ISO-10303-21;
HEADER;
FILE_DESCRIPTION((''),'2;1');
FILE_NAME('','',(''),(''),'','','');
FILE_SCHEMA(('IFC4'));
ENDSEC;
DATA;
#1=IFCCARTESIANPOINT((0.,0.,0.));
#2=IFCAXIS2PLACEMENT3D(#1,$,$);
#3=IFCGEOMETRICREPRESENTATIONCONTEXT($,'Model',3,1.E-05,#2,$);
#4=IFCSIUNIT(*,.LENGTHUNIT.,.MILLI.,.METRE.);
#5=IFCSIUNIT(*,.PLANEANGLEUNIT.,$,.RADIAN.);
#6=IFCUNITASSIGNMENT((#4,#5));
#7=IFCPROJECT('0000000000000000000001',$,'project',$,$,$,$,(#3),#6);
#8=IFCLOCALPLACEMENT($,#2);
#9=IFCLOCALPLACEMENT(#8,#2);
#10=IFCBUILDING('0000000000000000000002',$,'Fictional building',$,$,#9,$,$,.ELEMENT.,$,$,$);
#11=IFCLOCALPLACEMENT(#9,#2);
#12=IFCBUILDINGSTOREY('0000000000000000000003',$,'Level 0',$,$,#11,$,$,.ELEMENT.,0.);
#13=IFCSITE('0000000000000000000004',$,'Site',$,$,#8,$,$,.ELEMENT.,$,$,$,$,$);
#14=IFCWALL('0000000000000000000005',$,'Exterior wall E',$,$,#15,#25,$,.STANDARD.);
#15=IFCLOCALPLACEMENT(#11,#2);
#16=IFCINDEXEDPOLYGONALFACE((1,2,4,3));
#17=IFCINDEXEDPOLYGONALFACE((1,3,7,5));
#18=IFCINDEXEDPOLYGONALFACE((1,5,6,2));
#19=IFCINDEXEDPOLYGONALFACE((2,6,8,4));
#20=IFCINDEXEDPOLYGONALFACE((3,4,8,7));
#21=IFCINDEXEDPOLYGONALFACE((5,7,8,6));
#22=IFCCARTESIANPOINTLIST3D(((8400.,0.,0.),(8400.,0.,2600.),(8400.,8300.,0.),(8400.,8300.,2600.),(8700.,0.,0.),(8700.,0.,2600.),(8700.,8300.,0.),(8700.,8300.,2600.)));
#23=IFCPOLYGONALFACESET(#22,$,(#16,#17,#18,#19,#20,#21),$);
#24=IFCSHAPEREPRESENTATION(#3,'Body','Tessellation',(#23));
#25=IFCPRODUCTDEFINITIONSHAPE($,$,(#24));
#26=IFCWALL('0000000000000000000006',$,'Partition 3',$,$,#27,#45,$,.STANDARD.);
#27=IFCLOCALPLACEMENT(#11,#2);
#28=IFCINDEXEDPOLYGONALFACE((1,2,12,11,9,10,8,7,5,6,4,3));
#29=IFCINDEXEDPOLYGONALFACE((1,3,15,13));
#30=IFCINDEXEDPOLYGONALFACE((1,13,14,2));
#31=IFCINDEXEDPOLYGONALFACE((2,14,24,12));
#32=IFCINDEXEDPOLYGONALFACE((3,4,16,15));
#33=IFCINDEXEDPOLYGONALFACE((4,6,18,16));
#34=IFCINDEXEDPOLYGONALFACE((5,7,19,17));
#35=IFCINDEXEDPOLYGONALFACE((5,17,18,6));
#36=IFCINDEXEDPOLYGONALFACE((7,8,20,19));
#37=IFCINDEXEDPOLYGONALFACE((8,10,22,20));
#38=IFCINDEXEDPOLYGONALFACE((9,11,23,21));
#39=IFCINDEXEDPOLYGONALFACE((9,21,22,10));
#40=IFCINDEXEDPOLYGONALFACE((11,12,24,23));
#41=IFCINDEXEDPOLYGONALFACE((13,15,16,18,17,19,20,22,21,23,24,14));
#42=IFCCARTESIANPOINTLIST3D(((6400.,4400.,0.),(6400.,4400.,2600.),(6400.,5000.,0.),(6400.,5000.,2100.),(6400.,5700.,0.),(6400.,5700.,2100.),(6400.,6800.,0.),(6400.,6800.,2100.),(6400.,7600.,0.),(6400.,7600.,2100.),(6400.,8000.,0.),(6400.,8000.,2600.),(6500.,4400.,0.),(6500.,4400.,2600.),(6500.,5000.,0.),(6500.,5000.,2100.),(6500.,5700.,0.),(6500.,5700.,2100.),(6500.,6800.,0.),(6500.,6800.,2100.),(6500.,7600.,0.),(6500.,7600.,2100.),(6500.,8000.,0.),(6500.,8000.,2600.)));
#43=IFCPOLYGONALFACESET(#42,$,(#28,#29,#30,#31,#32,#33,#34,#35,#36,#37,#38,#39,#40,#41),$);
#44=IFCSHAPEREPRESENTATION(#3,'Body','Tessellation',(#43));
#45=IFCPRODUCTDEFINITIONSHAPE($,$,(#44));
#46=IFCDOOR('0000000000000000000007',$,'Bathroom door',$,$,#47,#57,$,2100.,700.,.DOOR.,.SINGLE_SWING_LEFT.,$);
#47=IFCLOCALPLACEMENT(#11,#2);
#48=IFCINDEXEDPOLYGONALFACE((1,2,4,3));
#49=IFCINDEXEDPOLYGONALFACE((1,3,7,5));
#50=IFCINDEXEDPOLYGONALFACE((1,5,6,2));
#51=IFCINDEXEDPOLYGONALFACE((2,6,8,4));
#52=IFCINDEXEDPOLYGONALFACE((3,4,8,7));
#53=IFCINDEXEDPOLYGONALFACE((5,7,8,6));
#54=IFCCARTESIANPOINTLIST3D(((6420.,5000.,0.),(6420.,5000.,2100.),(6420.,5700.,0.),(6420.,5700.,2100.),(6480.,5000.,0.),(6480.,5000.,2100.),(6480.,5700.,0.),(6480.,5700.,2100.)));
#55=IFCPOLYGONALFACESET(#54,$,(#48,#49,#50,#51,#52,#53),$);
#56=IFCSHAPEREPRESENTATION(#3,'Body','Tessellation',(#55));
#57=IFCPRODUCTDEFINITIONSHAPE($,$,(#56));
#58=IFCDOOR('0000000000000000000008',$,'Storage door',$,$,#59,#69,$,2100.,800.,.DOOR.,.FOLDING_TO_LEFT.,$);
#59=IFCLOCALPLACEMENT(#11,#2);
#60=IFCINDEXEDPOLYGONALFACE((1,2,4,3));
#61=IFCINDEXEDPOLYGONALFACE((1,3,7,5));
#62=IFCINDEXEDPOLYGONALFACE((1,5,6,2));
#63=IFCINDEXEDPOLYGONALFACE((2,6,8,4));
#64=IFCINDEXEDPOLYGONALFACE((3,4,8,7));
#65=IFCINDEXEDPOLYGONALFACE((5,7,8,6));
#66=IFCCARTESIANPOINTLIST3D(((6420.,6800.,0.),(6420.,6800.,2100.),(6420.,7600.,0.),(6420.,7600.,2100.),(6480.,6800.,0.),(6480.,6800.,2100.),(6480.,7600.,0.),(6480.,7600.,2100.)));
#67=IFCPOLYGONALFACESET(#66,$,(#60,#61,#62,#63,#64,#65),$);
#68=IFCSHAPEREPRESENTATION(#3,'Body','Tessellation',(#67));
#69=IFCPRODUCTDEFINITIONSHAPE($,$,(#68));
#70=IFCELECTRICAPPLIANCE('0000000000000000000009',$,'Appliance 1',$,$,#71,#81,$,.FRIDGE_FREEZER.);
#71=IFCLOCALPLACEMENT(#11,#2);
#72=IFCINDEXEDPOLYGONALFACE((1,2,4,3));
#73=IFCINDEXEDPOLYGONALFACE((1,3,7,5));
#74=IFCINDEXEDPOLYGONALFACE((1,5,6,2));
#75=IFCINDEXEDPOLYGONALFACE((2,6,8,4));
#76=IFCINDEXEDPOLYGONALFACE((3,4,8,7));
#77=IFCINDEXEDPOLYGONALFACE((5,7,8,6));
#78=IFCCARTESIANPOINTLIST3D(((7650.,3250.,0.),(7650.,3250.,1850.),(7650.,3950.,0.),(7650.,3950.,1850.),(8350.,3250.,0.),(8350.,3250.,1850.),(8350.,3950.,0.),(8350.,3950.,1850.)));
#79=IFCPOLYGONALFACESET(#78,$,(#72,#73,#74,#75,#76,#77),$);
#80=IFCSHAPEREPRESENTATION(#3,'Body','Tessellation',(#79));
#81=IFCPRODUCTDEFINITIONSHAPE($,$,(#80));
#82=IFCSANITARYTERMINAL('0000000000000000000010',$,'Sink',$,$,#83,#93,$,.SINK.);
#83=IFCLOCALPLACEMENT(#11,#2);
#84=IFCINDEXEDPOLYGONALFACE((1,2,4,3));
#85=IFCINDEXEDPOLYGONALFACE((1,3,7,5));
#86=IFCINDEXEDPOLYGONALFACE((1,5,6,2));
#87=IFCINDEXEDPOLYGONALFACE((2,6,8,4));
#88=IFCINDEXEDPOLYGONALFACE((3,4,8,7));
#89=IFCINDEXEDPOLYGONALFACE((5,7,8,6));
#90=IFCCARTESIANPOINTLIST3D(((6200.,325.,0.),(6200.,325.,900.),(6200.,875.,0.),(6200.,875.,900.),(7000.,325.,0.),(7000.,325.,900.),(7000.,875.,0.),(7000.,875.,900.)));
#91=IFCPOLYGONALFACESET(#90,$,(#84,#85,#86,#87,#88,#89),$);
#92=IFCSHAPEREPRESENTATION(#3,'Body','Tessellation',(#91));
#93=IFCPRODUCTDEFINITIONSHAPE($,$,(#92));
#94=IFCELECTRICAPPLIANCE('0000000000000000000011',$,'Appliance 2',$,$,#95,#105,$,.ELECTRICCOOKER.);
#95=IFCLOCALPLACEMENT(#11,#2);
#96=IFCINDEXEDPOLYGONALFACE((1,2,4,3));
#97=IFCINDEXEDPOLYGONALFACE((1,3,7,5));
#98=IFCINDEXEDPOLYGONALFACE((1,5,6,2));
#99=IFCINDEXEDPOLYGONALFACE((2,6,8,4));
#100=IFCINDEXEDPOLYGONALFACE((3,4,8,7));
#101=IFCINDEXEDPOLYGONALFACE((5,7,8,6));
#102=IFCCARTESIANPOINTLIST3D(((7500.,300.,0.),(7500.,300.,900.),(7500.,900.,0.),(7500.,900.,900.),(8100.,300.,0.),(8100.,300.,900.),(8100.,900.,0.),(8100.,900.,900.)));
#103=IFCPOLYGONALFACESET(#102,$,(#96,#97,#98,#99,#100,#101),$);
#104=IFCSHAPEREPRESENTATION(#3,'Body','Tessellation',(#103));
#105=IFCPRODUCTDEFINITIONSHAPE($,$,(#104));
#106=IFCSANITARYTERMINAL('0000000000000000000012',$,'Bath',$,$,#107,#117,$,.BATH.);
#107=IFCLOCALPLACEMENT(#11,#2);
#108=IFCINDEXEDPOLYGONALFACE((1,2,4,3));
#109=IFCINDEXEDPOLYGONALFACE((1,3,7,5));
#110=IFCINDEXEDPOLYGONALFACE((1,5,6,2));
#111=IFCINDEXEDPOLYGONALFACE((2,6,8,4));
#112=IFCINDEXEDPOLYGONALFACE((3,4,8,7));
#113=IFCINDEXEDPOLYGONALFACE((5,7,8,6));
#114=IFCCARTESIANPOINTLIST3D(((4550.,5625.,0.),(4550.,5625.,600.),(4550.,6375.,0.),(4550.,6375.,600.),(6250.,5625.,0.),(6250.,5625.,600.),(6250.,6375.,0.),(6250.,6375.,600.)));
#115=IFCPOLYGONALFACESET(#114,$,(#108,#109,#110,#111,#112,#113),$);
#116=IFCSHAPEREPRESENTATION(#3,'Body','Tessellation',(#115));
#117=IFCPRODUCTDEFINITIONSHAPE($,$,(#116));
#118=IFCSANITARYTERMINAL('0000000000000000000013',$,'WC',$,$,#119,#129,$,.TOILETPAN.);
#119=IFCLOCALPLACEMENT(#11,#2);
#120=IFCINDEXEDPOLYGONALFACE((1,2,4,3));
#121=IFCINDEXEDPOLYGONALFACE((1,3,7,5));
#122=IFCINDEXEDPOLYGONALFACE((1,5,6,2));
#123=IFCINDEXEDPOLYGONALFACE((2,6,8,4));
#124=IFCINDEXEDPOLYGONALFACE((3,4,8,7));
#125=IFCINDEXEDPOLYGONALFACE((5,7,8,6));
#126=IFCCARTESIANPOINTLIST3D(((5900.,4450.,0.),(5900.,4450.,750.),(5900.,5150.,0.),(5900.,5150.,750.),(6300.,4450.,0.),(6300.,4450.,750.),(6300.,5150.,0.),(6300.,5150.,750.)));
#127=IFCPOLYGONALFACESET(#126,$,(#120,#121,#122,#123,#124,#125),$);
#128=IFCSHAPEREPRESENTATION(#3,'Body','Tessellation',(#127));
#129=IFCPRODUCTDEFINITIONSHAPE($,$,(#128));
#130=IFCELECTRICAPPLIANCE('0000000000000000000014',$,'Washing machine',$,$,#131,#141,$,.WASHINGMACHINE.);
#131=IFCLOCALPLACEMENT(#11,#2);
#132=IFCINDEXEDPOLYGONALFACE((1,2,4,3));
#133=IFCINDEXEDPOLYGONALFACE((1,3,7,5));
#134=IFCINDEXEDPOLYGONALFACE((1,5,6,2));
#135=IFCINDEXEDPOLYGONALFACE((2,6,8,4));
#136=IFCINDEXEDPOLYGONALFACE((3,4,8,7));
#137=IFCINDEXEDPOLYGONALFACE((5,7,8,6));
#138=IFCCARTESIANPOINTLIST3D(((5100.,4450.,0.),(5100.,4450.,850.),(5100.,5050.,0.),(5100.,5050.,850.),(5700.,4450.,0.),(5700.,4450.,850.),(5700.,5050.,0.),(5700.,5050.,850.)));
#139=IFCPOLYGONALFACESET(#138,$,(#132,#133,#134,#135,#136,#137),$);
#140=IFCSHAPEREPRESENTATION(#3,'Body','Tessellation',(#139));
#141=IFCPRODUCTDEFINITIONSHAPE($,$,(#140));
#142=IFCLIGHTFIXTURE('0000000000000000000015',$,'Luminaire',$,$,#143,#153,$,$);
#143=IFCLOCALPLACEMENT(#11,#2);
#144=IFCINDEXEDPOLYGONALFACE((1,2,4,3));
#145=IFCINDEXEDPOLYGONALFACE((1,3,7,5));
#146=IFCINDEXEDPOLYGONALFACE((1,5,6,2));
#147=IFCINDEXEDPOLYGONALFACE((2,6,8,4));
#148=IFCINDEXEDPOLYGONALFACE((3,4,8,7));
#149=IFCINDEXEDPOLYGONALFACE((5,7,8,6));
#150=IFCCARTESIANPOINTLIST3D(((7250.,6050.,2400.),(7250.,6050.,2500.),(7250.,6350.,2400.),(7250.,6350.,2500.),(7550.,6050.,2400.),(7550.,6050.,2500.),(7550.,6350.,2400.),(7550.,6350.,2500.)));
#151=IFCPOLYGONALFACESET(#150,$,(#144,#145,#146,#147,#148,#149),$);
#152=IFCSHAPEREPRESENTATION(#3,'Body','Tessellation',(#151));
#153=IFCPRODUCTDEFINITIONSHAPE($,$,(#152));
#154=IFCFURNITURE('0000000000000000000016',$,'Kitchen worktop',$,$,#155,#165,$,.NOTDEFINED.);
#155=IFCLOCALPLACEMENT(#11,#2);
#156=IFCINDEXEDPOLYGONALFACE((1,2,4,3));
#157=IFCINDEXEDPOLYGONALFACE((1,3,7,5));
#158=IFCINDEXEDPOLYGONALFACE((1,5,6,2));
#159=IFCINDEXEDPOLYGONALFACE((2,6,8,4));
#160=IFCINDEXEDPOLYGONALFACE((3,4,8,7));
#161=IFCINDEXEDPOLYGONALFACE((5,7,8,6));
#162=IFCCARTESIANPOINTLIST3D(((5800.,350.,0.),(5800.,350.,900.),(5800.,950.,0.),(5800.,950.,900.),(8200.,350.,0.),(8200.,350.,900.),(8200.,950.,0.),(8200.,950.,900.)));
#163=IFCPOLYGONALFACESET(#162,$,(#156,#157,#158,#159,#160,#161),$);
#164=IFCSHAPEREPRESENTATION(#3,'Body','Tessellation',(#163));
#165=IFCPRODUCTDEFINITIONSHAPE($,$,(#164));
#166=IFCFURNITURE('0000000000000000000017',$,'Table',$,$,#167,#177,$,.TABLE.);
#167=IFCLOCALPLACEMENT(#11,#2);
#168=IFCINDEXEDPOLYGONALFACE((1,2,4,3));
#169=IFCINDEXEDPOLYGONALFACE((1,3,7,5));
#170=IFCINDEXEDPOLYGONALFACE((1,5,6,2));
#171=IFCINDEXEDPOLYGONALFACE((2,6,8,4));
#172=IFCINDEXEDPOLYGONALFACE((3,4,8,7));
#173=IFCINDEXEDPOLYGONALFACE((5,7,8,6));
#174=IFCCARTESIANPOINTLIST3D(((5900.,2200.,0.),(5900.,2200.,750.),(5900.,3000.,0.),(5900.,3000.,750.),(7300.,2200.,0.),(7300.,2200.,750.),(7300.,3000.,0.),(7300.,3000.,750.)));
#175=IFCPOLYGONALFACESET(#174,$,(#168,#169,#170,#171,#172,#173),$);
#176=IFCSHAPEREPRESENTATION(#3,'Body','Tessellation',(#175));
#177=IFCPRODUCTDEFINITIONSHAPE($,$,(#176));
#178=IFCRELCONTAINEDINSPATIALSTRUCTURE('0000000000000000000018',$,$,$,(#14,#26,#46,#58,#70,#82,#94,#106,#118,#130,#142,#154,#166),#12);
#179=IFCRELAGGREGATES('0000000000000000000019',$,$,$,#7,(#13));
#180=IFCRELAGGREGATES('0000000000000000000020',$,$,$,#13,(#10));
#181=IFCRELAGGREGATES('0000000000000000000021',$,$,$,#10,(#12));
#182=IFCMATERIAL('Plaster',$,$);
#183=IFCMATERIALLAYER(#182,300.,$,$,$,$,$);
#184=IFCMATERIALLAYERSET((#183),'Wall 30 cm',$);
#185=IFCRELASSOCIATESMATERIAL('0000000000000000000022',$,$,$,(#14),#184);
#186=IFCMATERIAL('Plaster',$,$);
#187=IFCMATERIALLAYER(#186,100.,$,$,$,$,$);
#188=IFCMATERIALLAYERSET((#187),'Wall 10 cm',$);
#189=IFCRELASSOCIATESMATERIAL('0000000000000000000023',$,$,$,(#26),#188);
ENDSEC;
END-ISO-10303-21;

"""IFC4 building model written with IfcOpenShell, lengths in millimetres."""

from ifc_helpers import new_model, si_unit, frame, frame_2d, origin, origin_2d, place, context, project, spatial, rectangle, extrude, source, transform, mapped, material, layer, layer_set, layer_usage, element, fill, save


model = new_model("IFC4")

# Units and contexts
model_context = context("Model", 3, precision=1e-05, world=origin())
ifc_project = project(units=[si_unit("LENGTHUNIT", "METRE", prefix="MILLI"), si_unit("PLANEANGLEUNIT", "RADIAN")], contexts=[model_context])

# Site, building, storey
site_placement = place(None, origin())
site = spatial("IfcSite", under=ifc_project, at=site_placement, Name="Site", CompositionType="ELEMENT")
building_placement = place(site_placement, origin())
building = spatial("IfcBuilding", under=site, at=building_placement, Name="Fictional building", CompositionType="ELEMENT")
storey_placement = place(building_placement, origin())
storey = spatial("IfcBuildingStorey", under=building, at=storey_placement, Name="Level 0", CompositionType="ELEMENT", Elevation=0.0)

# Wall
ifc_material_1 = material(Name="Plaster")
ifc_layer_1 = layer(ifc_material_1, 300.0)
ifc_layer_set_1 = layer_set([ifc_layer_1], Name="Wall 30 cm")
ifc_layer_usage_1 = layer_usage(ifc_layer_set_1, "AXIS2", "POSITIVE", -150.0)
wall_1_placement = place(storey_placement, frame((8550.0, 0.0, 0.0), z_axis=(0.0, 0.0, 1.0), x_axis=(0.0, 1.0, 0.0)))
element("IfcWall", 1, at=wall_1_placement, inside=storey, material=ifc_layer_usage_1, Name="Exterior wall E", PredefinedType="STANDARD", context=model_context, shape_type="SweptSolid", body=[
    extrude(rectangle(XDim=8300.0, YDim=300.0, at=frame_2d((4150.0, 0.0))), origin(), (0.0, 0.0, 1.0), 2600.0),
])

# Wall, openings, doors
ifc_material_2 = material(Name="Plaster")
ifc_layer_2 = layer(ifc_material_2, 100.0)
ifc_layer_set_2 = layer_set([ifc_layer_2], Name="Wall 10 cm")
ifc_layer_usage_2 = layer_usage(ifc_layer_set_2, "AXIS2", "POSITIVE", -50.0)
wall_2_placement = place(storey_placement, frame((6450.0, 4400.0, 0.0), z_axis=(0.0, 0.0, 1.0), x_axis=(0.0, 1.0, 0.0)))
wall_2 = element("IfcWall", 2, at=wall_2_placement, inside=storey, material=ifc_layer_usage_2, Name="Partition 3", PredefinedType="STANDARD", context=model_context, shape_type="SweptSolid", body=[
    extrude(rectangle(XDim=3600.0, YDim=100.0, at=frame_2d((1800.0, 0.0))), origin(), (0.0, 0.0, 1.0), 2600.0),
])
opening_1_placement = place(storey_placement, frame((6450.0, 5000.0, 0.0), z_axis=(0.0, 0.0, 1.0), x_axis=(0.0, 1.0, 0.0)))
opening_1 = element("IfcOpeningElement", 3, at=opening_1_placement, cuts=wall_2, PredefinedType="OPENING", context=model_context, shape_type="SweptSolid", body=[
    extrude(rectangle(XDim=700.0, YDim=200.0, at=frame_2d((350.0, 0.0))), origin(), (0.0, 0.0, 1.0), 2100.0),
])
opening_2_placement = place(storey_placement, frame((6450.0, 6800.0, 0.0), z_axis=(0.0, 0.0, 1.0), x_axis=(0.0, 1.0, 0.0)))
opening_2 = element("IfcOpeningElement", 4, at=opening_2_placement, cuts=wall_2, PredefinedType="OPENING", context=model_context, shape_type="SweptSolid", body=[
    extrude(rectangle(XDim=800.0, YDim=200.0, at=frame_2d((400.0, 0.0))), origin(), (0.0, 0.0, 1.0), 2100.0),
])
door_1_placement = place(opening_1_placement, origin())
door_1 = element("IfcDoor", 5, at=door_1_placement, inside=storey, Name="Bathroom door", OperationType="SINGLE_SWING_LEFT", OverallHeight=2100.0, OverallWidth=700.0, PredefinedType="DOOR", context=model_context, shape_type="SweptSolid", body=[
    extrude(rectangle(XDim=700.0, YDim=60.0, at=frame_2d((350.0, 0.0))), origin(), (0.0, 0.0, 1.0), 2100.0),
])
fill(opening_1, door_1)
door_2_placement = place(opening_2_placement, origin())
door_2 = element("IfcDoor", 6, at=door_2_placement, inside=storey, Name="Storage door", OperationType="FOLDING_TO_LEFT", OverallHeight=2100.0, OverallWidth=800.0, PredefinedType="DOOR", context=model_context, shape_type="SweptSolid", body=[
    extrude(rectangle(XDim=800.0, YDim=60.0, at=frame_2d((400.0, 0.0))), origin(), (0.0, 0.0, 1.0), 2100.0),
])
fill(opening_2, door_2)

# Electric appliance
shared_shape_1 = source(origin(), model_context, "Body", "SweptSolid", [
    extrude(rectangle(XDim=700.0, YDim=700.0, at=origin_2d()), origin(), (0.0, 0.0, 1.0), 1850.0),
])
electric_appliance_1_placement = place(storey_placement, frame((8000.0, 3600.0, 0.0), z_axis=(0.0, 0.0, 1.0), x_axis=(0.0, -1.0, 0.0)))
element("IfcElectricAppliance", 7, at=electric_appliance_1_placement, inside=storey, Name="Appliance 1", PredefinedType="FRIDGE_FREEZER", context=model_context, shape_type="MappedRepresentation", body=[
    mapped(shared_shape_1, transform((0.0, 0.0, 0.0), scale=1.0)),
])

# Sanitary terminal
shared_shape_2 = source(origin(), model_context, "Body", "SweptSolid", [
    extrude(rectangle(XDim=800.0, YDim=550.0, at=origin_2d()), origin(), (0.0, 0.0, 1.0), 900.0),
])
sanitary_terminal_1_placement = place(storey_placement, frame((6600.0, 600.0, 0.0)))
element("IfcSanitaryTerminal", 8, at=sanitary_terminal_1_placement, inside=storey, Name="Sink", PredefinedType="SINK", context=model_context, shape_type="MappedRepresentation", body=[
    mapped(shared_shape_2, transform((0.0, 0.0, 0.0), scale=1.0)),
])

# Electric appliance
shared_shape_3 = source(origin(), model_context, "Body", "SweptSolid", [
    extrude(rectangle(XDim=600.0, YDim=600.0, at=origin_2d()), origin(), (0.0, 0.0, 1.0), 900.0),
])
electric_appliance_2_placement = place(storey_placement, frame((7800.0, 600.0, 0.0)))
element("IfcElectricAppliance", 9, at=electric_appliance_2_placement, inside=storey, Name="Appliance 2", PredefinedType="ELECTRICCOOKER", context=model_context, shape_type="MappedRepresentation", body=[
    mapped(shared_shape_3, transform((0.0, 0.0, 0.0), scale=1.0)),
])

# Sanitary terminals
shared_shape_4 = source(origin(), model_context, "Body", "SweptSolid", [
    extrude(rectangle(XDim=1700.0, YDim=750.0, at=origin_2d()), origin(), (0.0, 0.0, 1.0), 600.0),
])
sanitary_terminal_2_placement = place(storey_placement, frame((5400.0, 6000.0, 0.0)))
element("IfcSanitaryTerminal", 10, at=sanitary_terminal_2_placement, inside=storey, Name="Bath", PredefinedType="BATH", context=model_context, shape_type="MappedRepresentation", body=[
    mapped(shared_shape_4, transform((0.0, 0.0, 0.0), scale=1.0)),
])
shared_shape_5 = source(origin(), model_context, "Body", "SweptSolid", [
    extrude(rectangle(XDim=400.0, YDim=700.0, at=origin_2d()), origin(), (0.0, 0.0, 1.0), 750.0),
])
sanitary_terminal_3_placement = place(storey_placement, frame((6100.0, 4800.0, 0.0)))
element("IfcSanitaryTerminal", 11, at=sanitary_terminal_3_placement, inside=storey, Name="WC", PredefinedType="TOILETPAN", context=model_context, shape_type="MappedRepresentation", body=[
    mapped(shared_shape_5, transform((0.0, 0.0, 0.0), scale=1.0)),
])

# Electric appliance
shared_shape_6 = source(origin(), model_context, "Body", "SweptSolid", [
    extrude(rectangle(XDim=600.0, YDim=600.0, at=origin_2d()), origin(), (0.0, 0.0, 1.0), 850.0),
])
electric_appliance_3_placement = place(storey_placement, frame((5400.0, 4750.0, 0.0)))
element("IfcElectricAppliance", 12, at=electric_appliance_3_placement, inside=storey, Name="Washing machine", PredefinedType="WASHINGMACHINE", context=model_context, shape_type="MappedRepresentation", body=[
    mapped(shared_shape_6, transform((0.0, 0.0, 0.0), scale=1.0)),
])

# Light fixture
shared_shape_7 = source(origin(), model_context, "Body", "SweptSolid", [
    extrude(rectangle(XDim=300.0, YDim=300.0, at=origin_2d()), origin(), (0.0, 0.0, 1.0), 100.0),
])
light_fixture_placement = place(storey_placement, frame((7400.0, 6200.0, 2400.0)))
element("IfcLightFixture", 13, at=light_fixture_placement, inside=storey, Name="Luminaire", context=model_context, shape_type="MappedRepresentation", body=[
    mapped(shared_shape_7, transform((0.0, 0.0, 0.0), scale=1.0)),
])

# Furniture
shared_shape_8 = source(origin(), model_context, "Body", "SweptSolid", [
    extrude(rectangle(XDim=2400.0, YDim=600.0, at=origin_2d()), origin(), (0.0, 0.0, 1.0), 900.0),
])
furniture_1_placement = place(storey_placement, frame((7000.0, 650.0, 0.0)))
element("IfcFurniture", 14, at=furniture_1_placement, inside=storey, Name="Kitchen worktop", PredefinedType="NOTDEFINED", context=model_context, shape_type="MappedRepresentation", body=[
    mapped(shared_shape_8, transform((0.0, 0.0, 0.0), scale=1.0)),
])
shared_shape_9 = source(origin(), model_context, "Body", "SweptSolid", [
    extrude(rectangle(XDim=1400.0, YDim=800.0, at=origin_2d()), origin(), (0.0, 0.0, 1.0), 750.0),
])
furniture_2_placement = place(storey_placement, frame((6600.0, 2600.0, 0.0)))
element("IfcFurniture", 15, at=furniture_2_placement, inside=storey, Name="Table", PredefinedType="TABLE", context=model_context, shape_type="MappedRepresentation", body=[
    mapped(shared_shape_9, transform((0.0, 0.0, 0.0), scale=1.0)),
])

save(model, "model.ifc")
